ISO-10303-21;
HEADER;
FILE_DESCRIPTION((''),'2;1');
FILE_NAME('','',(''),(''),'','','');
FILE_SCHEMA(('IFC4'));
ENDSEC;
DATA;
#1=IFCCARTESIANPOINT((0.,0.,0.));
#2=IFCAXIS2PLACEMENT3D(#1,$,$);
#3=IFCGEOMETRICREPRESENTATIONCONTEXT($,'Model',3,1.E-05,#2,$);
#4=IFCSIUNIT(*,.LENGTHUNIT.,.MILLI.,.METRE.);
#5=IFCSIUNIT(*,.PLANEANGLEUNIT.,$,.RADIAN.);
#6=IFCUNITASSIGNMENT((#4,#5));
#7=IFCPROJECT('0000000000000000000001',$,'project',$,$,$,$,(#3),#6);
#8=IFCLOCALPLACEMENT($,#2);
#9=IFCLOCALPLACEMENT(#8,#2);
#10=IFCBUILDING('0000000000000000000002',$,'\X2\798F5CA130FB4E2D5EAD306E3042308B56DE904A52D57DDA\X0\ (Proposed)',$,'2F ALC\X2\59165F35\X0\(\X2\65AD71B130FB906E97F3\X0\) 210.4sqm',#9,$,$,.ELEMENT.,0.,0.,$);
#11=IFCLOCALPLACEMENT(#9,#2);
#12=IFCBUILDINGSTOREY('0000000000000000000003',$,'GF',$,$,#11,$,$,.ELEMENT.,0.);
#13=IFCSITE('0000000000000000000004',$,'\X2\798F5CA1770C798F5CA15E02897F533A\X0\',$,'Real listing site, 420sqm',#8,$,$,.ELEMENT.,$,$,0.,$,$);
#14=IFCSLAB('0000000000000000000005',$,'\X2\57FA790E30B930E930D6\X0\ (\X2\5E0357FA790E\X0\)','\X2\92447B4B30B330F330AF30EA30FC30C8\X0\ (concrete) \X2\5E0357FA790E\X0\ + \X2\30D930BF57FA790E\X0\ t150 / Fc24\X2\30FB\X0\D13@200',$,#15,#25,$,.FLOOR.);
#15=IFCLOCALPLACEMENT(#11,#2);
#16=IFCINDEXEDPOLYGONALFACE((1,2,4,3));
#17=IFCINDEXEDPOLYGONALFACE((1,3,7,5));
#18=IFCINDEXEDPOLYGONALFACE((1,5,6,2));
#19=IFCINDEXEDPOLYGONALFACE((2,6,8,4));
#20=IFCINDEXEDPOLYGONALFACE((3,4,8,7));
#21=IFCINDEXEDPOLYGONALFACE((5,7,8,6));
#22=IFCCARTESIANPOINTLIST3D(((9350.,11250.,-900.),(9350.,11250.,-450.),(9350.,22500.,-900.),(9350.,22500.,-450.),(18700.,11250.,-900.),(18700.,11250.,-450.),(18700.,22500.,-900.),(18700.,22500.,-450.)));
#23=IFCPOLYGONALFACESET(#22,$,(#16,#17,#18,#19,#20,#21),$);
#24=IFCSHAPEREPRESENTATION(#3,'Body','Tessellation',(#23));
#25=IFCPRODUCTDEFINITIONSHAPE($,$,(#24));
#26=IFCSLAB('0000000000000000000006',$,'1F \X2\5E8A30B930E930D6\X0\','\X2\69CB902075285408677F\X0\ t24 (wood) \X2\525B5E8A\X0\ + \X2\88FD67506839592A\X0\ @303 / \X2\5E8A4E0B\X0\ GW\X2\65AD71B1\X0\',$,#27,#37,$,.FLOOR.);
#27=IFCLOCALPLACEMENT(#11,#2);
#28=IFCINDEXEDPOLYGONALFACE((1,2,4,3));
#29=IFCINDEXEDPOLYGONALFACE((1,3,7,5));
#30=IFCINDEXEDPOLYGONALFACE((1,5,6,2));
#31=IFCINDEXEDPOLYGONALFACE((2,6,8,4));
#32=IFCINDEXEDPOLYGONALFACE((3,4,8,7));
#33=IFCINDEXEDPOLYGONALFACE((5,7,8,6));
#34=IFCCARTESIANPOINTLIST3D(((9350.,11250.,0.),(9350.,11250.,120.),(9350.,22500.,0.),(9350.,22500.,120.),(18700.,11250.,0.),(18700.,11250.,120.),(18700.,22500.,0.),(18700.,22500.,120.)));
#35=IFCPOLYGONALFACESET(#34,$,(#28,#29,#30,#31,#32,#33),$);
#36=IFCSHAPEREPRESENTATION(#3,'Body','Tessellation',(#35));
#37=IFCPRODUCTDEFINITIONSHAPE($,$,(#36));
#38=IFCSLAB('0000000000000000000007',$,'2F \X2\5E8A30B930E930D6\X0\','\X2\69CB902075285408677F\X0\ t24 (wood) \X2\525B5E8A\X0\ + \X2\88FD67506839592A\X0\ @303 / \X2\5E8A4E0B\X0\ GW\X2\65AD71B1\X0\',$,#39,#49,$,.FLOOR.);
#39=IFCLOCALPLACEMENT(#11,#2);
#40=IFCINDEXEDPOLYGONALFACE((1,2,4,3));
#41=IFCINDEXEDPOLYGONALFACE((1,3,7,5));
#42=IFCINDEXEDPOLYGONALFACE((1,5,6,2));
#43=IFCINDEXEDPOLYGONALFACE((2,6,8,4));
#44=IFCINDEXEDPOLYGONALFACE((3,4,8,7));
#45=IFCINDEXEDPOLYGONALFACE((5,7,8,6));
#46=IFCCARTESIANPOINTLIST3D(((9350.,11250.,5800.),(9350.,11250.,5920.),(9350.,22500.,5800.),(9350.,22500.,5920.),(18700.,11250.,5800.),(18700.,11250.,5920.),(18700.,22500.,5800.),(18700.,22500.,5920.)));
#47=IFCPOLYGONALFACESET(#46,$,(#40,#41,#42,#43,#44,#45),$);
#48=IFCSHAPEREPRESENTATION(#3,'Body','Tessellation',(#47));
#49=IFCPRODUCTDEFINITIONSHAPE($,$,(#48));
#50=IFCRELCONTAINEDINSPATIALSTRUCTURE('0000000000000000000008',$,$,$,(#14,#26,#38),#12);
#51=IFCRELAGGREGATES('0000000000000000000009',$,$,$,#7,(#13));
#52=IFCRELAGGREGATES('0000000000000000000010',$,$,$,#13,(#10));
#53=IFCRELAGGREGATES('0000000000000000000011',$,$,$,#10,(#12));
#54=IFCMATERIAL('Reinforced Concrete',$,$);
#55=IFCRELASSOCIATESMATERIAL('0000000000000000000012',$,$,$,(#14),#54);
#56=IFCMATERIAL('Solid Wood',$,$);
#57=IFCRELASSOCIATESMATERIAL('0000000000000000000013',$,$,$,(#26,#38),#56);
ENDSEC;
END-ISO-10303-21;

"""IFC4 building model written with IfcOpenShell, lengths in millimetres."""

from ifc_helpers import new_model, si_unit, frame, frame_2d, origin, place, context, project, spatial, rectangle, extrude, material, element, save


model = new_model("IFC4")

# Units and contexts
model_context = context("Model", 3, precision=1e-05, world=origin())
ifc_project = project(units=[si_unit("LENGTHUNIT", "METRE", prefix="MILLI"), si_unit("PLANEANGLEUNIT", "RADIAN")], contexts=[model_context])

# Site, building, storey
site_placement = place(None, origin())
site = spatial("IfcSite", under=ifc_project, at=site_placement, Name="福岡県福岡市西区", ObjectType="Real listing site, 420sqm", CompositionType="ELEMENT", RefElevation=0.0)
building_placement = place(site_placement, origin())
building = spatial("IfcBuilding", under=site, at=building_placement, Name="福岡・中庭のある回遊動線 (Proposed)", ObjectType="2F ALC外張(断熱・遮音) 210.4sqm", CompositionType="ELEMENT", ElevationOfRefHeight=0.0, ElevationOfTerrain=0.0)
storey_placement = place(building_placement, origin())
storey = spatial("IfcBuildingStorey", under=building, at=storey_placement, Name="GF", CompositionType="ELEMENT", Elevation=0.0)

# Shared definitions
ifc_material_1 = material(Name="Solid Wood")

# Slabs
ifc_material_2 = material(Name="Reinforced Concrete")
slab_1_placement = place(storey_placement, frame((4675.0, 5625.0, -450.0)))
element("IfcSlab", 1, at=slab_1_placement, inside=storey, material=ifc_material_2, Name="基礎スラブ (布基礎)", Description="鉄筋コンクリート (concrete) 布基礎 + ベタ基礎 t150 / Fc24・D13@200", PredefinedType="FLOOR", context=model_context, shape_type="SweptSolid", body=[
    extrude(rectangle(XDim=9350.0, YDim=11250.0, at=frame_2d((4675.0, 5625.0))), frame((4675.0, 5625.0, -450.0)), (0.0, 0.0, 1.0), 450.0),
])
slab_2_placement = place(storey_placement, frame((4675.0, 5625.0, 0.0)))
element("IfcSlab", 2, at=slab_2_placement, inside=storey, material=ifc_material_1, Name="1F 床スラブ", Description="構造用合板 t24 (wood) 剛床 + 製材根太 @303 / 床下 GW断熱", PredefinedType="FLOOR", context=model_context, shape_type="SweptSolid", body=[
    extrude(rectangle(XDim=9350.0, YDim=11250.0, at=frame_2d((4675.0, 5625.0))), frame((4675.0, 5625.0, 0.0)), (0.0, 0.0, 1.0), 120.0),
])
slab_3_placement = place(storey_placement, frame((4675.0, 5625.0, 2900.0)))
element("IfcSlab", 3, at=slab_3_placement, inside=storey, material=ifc_material_1, Name="2F 床スラブ", Description="構造用合板 t24 (wood) 剛床 + 製材根太 @303 / 床下 GW断熱", PredefinedType="FLOOR", context=model_context, shape_type="SweptSolid", body=[
    extrude(rectangle(XDim=9350.0, YDim=11250.0, at=frame_2d((4675.0, 5625.0))), frame((4675.0, 5625.0, 2900.0)), (0.0, 0.0, 1.0), 120.0),
])

save(model, "model.ifc")
